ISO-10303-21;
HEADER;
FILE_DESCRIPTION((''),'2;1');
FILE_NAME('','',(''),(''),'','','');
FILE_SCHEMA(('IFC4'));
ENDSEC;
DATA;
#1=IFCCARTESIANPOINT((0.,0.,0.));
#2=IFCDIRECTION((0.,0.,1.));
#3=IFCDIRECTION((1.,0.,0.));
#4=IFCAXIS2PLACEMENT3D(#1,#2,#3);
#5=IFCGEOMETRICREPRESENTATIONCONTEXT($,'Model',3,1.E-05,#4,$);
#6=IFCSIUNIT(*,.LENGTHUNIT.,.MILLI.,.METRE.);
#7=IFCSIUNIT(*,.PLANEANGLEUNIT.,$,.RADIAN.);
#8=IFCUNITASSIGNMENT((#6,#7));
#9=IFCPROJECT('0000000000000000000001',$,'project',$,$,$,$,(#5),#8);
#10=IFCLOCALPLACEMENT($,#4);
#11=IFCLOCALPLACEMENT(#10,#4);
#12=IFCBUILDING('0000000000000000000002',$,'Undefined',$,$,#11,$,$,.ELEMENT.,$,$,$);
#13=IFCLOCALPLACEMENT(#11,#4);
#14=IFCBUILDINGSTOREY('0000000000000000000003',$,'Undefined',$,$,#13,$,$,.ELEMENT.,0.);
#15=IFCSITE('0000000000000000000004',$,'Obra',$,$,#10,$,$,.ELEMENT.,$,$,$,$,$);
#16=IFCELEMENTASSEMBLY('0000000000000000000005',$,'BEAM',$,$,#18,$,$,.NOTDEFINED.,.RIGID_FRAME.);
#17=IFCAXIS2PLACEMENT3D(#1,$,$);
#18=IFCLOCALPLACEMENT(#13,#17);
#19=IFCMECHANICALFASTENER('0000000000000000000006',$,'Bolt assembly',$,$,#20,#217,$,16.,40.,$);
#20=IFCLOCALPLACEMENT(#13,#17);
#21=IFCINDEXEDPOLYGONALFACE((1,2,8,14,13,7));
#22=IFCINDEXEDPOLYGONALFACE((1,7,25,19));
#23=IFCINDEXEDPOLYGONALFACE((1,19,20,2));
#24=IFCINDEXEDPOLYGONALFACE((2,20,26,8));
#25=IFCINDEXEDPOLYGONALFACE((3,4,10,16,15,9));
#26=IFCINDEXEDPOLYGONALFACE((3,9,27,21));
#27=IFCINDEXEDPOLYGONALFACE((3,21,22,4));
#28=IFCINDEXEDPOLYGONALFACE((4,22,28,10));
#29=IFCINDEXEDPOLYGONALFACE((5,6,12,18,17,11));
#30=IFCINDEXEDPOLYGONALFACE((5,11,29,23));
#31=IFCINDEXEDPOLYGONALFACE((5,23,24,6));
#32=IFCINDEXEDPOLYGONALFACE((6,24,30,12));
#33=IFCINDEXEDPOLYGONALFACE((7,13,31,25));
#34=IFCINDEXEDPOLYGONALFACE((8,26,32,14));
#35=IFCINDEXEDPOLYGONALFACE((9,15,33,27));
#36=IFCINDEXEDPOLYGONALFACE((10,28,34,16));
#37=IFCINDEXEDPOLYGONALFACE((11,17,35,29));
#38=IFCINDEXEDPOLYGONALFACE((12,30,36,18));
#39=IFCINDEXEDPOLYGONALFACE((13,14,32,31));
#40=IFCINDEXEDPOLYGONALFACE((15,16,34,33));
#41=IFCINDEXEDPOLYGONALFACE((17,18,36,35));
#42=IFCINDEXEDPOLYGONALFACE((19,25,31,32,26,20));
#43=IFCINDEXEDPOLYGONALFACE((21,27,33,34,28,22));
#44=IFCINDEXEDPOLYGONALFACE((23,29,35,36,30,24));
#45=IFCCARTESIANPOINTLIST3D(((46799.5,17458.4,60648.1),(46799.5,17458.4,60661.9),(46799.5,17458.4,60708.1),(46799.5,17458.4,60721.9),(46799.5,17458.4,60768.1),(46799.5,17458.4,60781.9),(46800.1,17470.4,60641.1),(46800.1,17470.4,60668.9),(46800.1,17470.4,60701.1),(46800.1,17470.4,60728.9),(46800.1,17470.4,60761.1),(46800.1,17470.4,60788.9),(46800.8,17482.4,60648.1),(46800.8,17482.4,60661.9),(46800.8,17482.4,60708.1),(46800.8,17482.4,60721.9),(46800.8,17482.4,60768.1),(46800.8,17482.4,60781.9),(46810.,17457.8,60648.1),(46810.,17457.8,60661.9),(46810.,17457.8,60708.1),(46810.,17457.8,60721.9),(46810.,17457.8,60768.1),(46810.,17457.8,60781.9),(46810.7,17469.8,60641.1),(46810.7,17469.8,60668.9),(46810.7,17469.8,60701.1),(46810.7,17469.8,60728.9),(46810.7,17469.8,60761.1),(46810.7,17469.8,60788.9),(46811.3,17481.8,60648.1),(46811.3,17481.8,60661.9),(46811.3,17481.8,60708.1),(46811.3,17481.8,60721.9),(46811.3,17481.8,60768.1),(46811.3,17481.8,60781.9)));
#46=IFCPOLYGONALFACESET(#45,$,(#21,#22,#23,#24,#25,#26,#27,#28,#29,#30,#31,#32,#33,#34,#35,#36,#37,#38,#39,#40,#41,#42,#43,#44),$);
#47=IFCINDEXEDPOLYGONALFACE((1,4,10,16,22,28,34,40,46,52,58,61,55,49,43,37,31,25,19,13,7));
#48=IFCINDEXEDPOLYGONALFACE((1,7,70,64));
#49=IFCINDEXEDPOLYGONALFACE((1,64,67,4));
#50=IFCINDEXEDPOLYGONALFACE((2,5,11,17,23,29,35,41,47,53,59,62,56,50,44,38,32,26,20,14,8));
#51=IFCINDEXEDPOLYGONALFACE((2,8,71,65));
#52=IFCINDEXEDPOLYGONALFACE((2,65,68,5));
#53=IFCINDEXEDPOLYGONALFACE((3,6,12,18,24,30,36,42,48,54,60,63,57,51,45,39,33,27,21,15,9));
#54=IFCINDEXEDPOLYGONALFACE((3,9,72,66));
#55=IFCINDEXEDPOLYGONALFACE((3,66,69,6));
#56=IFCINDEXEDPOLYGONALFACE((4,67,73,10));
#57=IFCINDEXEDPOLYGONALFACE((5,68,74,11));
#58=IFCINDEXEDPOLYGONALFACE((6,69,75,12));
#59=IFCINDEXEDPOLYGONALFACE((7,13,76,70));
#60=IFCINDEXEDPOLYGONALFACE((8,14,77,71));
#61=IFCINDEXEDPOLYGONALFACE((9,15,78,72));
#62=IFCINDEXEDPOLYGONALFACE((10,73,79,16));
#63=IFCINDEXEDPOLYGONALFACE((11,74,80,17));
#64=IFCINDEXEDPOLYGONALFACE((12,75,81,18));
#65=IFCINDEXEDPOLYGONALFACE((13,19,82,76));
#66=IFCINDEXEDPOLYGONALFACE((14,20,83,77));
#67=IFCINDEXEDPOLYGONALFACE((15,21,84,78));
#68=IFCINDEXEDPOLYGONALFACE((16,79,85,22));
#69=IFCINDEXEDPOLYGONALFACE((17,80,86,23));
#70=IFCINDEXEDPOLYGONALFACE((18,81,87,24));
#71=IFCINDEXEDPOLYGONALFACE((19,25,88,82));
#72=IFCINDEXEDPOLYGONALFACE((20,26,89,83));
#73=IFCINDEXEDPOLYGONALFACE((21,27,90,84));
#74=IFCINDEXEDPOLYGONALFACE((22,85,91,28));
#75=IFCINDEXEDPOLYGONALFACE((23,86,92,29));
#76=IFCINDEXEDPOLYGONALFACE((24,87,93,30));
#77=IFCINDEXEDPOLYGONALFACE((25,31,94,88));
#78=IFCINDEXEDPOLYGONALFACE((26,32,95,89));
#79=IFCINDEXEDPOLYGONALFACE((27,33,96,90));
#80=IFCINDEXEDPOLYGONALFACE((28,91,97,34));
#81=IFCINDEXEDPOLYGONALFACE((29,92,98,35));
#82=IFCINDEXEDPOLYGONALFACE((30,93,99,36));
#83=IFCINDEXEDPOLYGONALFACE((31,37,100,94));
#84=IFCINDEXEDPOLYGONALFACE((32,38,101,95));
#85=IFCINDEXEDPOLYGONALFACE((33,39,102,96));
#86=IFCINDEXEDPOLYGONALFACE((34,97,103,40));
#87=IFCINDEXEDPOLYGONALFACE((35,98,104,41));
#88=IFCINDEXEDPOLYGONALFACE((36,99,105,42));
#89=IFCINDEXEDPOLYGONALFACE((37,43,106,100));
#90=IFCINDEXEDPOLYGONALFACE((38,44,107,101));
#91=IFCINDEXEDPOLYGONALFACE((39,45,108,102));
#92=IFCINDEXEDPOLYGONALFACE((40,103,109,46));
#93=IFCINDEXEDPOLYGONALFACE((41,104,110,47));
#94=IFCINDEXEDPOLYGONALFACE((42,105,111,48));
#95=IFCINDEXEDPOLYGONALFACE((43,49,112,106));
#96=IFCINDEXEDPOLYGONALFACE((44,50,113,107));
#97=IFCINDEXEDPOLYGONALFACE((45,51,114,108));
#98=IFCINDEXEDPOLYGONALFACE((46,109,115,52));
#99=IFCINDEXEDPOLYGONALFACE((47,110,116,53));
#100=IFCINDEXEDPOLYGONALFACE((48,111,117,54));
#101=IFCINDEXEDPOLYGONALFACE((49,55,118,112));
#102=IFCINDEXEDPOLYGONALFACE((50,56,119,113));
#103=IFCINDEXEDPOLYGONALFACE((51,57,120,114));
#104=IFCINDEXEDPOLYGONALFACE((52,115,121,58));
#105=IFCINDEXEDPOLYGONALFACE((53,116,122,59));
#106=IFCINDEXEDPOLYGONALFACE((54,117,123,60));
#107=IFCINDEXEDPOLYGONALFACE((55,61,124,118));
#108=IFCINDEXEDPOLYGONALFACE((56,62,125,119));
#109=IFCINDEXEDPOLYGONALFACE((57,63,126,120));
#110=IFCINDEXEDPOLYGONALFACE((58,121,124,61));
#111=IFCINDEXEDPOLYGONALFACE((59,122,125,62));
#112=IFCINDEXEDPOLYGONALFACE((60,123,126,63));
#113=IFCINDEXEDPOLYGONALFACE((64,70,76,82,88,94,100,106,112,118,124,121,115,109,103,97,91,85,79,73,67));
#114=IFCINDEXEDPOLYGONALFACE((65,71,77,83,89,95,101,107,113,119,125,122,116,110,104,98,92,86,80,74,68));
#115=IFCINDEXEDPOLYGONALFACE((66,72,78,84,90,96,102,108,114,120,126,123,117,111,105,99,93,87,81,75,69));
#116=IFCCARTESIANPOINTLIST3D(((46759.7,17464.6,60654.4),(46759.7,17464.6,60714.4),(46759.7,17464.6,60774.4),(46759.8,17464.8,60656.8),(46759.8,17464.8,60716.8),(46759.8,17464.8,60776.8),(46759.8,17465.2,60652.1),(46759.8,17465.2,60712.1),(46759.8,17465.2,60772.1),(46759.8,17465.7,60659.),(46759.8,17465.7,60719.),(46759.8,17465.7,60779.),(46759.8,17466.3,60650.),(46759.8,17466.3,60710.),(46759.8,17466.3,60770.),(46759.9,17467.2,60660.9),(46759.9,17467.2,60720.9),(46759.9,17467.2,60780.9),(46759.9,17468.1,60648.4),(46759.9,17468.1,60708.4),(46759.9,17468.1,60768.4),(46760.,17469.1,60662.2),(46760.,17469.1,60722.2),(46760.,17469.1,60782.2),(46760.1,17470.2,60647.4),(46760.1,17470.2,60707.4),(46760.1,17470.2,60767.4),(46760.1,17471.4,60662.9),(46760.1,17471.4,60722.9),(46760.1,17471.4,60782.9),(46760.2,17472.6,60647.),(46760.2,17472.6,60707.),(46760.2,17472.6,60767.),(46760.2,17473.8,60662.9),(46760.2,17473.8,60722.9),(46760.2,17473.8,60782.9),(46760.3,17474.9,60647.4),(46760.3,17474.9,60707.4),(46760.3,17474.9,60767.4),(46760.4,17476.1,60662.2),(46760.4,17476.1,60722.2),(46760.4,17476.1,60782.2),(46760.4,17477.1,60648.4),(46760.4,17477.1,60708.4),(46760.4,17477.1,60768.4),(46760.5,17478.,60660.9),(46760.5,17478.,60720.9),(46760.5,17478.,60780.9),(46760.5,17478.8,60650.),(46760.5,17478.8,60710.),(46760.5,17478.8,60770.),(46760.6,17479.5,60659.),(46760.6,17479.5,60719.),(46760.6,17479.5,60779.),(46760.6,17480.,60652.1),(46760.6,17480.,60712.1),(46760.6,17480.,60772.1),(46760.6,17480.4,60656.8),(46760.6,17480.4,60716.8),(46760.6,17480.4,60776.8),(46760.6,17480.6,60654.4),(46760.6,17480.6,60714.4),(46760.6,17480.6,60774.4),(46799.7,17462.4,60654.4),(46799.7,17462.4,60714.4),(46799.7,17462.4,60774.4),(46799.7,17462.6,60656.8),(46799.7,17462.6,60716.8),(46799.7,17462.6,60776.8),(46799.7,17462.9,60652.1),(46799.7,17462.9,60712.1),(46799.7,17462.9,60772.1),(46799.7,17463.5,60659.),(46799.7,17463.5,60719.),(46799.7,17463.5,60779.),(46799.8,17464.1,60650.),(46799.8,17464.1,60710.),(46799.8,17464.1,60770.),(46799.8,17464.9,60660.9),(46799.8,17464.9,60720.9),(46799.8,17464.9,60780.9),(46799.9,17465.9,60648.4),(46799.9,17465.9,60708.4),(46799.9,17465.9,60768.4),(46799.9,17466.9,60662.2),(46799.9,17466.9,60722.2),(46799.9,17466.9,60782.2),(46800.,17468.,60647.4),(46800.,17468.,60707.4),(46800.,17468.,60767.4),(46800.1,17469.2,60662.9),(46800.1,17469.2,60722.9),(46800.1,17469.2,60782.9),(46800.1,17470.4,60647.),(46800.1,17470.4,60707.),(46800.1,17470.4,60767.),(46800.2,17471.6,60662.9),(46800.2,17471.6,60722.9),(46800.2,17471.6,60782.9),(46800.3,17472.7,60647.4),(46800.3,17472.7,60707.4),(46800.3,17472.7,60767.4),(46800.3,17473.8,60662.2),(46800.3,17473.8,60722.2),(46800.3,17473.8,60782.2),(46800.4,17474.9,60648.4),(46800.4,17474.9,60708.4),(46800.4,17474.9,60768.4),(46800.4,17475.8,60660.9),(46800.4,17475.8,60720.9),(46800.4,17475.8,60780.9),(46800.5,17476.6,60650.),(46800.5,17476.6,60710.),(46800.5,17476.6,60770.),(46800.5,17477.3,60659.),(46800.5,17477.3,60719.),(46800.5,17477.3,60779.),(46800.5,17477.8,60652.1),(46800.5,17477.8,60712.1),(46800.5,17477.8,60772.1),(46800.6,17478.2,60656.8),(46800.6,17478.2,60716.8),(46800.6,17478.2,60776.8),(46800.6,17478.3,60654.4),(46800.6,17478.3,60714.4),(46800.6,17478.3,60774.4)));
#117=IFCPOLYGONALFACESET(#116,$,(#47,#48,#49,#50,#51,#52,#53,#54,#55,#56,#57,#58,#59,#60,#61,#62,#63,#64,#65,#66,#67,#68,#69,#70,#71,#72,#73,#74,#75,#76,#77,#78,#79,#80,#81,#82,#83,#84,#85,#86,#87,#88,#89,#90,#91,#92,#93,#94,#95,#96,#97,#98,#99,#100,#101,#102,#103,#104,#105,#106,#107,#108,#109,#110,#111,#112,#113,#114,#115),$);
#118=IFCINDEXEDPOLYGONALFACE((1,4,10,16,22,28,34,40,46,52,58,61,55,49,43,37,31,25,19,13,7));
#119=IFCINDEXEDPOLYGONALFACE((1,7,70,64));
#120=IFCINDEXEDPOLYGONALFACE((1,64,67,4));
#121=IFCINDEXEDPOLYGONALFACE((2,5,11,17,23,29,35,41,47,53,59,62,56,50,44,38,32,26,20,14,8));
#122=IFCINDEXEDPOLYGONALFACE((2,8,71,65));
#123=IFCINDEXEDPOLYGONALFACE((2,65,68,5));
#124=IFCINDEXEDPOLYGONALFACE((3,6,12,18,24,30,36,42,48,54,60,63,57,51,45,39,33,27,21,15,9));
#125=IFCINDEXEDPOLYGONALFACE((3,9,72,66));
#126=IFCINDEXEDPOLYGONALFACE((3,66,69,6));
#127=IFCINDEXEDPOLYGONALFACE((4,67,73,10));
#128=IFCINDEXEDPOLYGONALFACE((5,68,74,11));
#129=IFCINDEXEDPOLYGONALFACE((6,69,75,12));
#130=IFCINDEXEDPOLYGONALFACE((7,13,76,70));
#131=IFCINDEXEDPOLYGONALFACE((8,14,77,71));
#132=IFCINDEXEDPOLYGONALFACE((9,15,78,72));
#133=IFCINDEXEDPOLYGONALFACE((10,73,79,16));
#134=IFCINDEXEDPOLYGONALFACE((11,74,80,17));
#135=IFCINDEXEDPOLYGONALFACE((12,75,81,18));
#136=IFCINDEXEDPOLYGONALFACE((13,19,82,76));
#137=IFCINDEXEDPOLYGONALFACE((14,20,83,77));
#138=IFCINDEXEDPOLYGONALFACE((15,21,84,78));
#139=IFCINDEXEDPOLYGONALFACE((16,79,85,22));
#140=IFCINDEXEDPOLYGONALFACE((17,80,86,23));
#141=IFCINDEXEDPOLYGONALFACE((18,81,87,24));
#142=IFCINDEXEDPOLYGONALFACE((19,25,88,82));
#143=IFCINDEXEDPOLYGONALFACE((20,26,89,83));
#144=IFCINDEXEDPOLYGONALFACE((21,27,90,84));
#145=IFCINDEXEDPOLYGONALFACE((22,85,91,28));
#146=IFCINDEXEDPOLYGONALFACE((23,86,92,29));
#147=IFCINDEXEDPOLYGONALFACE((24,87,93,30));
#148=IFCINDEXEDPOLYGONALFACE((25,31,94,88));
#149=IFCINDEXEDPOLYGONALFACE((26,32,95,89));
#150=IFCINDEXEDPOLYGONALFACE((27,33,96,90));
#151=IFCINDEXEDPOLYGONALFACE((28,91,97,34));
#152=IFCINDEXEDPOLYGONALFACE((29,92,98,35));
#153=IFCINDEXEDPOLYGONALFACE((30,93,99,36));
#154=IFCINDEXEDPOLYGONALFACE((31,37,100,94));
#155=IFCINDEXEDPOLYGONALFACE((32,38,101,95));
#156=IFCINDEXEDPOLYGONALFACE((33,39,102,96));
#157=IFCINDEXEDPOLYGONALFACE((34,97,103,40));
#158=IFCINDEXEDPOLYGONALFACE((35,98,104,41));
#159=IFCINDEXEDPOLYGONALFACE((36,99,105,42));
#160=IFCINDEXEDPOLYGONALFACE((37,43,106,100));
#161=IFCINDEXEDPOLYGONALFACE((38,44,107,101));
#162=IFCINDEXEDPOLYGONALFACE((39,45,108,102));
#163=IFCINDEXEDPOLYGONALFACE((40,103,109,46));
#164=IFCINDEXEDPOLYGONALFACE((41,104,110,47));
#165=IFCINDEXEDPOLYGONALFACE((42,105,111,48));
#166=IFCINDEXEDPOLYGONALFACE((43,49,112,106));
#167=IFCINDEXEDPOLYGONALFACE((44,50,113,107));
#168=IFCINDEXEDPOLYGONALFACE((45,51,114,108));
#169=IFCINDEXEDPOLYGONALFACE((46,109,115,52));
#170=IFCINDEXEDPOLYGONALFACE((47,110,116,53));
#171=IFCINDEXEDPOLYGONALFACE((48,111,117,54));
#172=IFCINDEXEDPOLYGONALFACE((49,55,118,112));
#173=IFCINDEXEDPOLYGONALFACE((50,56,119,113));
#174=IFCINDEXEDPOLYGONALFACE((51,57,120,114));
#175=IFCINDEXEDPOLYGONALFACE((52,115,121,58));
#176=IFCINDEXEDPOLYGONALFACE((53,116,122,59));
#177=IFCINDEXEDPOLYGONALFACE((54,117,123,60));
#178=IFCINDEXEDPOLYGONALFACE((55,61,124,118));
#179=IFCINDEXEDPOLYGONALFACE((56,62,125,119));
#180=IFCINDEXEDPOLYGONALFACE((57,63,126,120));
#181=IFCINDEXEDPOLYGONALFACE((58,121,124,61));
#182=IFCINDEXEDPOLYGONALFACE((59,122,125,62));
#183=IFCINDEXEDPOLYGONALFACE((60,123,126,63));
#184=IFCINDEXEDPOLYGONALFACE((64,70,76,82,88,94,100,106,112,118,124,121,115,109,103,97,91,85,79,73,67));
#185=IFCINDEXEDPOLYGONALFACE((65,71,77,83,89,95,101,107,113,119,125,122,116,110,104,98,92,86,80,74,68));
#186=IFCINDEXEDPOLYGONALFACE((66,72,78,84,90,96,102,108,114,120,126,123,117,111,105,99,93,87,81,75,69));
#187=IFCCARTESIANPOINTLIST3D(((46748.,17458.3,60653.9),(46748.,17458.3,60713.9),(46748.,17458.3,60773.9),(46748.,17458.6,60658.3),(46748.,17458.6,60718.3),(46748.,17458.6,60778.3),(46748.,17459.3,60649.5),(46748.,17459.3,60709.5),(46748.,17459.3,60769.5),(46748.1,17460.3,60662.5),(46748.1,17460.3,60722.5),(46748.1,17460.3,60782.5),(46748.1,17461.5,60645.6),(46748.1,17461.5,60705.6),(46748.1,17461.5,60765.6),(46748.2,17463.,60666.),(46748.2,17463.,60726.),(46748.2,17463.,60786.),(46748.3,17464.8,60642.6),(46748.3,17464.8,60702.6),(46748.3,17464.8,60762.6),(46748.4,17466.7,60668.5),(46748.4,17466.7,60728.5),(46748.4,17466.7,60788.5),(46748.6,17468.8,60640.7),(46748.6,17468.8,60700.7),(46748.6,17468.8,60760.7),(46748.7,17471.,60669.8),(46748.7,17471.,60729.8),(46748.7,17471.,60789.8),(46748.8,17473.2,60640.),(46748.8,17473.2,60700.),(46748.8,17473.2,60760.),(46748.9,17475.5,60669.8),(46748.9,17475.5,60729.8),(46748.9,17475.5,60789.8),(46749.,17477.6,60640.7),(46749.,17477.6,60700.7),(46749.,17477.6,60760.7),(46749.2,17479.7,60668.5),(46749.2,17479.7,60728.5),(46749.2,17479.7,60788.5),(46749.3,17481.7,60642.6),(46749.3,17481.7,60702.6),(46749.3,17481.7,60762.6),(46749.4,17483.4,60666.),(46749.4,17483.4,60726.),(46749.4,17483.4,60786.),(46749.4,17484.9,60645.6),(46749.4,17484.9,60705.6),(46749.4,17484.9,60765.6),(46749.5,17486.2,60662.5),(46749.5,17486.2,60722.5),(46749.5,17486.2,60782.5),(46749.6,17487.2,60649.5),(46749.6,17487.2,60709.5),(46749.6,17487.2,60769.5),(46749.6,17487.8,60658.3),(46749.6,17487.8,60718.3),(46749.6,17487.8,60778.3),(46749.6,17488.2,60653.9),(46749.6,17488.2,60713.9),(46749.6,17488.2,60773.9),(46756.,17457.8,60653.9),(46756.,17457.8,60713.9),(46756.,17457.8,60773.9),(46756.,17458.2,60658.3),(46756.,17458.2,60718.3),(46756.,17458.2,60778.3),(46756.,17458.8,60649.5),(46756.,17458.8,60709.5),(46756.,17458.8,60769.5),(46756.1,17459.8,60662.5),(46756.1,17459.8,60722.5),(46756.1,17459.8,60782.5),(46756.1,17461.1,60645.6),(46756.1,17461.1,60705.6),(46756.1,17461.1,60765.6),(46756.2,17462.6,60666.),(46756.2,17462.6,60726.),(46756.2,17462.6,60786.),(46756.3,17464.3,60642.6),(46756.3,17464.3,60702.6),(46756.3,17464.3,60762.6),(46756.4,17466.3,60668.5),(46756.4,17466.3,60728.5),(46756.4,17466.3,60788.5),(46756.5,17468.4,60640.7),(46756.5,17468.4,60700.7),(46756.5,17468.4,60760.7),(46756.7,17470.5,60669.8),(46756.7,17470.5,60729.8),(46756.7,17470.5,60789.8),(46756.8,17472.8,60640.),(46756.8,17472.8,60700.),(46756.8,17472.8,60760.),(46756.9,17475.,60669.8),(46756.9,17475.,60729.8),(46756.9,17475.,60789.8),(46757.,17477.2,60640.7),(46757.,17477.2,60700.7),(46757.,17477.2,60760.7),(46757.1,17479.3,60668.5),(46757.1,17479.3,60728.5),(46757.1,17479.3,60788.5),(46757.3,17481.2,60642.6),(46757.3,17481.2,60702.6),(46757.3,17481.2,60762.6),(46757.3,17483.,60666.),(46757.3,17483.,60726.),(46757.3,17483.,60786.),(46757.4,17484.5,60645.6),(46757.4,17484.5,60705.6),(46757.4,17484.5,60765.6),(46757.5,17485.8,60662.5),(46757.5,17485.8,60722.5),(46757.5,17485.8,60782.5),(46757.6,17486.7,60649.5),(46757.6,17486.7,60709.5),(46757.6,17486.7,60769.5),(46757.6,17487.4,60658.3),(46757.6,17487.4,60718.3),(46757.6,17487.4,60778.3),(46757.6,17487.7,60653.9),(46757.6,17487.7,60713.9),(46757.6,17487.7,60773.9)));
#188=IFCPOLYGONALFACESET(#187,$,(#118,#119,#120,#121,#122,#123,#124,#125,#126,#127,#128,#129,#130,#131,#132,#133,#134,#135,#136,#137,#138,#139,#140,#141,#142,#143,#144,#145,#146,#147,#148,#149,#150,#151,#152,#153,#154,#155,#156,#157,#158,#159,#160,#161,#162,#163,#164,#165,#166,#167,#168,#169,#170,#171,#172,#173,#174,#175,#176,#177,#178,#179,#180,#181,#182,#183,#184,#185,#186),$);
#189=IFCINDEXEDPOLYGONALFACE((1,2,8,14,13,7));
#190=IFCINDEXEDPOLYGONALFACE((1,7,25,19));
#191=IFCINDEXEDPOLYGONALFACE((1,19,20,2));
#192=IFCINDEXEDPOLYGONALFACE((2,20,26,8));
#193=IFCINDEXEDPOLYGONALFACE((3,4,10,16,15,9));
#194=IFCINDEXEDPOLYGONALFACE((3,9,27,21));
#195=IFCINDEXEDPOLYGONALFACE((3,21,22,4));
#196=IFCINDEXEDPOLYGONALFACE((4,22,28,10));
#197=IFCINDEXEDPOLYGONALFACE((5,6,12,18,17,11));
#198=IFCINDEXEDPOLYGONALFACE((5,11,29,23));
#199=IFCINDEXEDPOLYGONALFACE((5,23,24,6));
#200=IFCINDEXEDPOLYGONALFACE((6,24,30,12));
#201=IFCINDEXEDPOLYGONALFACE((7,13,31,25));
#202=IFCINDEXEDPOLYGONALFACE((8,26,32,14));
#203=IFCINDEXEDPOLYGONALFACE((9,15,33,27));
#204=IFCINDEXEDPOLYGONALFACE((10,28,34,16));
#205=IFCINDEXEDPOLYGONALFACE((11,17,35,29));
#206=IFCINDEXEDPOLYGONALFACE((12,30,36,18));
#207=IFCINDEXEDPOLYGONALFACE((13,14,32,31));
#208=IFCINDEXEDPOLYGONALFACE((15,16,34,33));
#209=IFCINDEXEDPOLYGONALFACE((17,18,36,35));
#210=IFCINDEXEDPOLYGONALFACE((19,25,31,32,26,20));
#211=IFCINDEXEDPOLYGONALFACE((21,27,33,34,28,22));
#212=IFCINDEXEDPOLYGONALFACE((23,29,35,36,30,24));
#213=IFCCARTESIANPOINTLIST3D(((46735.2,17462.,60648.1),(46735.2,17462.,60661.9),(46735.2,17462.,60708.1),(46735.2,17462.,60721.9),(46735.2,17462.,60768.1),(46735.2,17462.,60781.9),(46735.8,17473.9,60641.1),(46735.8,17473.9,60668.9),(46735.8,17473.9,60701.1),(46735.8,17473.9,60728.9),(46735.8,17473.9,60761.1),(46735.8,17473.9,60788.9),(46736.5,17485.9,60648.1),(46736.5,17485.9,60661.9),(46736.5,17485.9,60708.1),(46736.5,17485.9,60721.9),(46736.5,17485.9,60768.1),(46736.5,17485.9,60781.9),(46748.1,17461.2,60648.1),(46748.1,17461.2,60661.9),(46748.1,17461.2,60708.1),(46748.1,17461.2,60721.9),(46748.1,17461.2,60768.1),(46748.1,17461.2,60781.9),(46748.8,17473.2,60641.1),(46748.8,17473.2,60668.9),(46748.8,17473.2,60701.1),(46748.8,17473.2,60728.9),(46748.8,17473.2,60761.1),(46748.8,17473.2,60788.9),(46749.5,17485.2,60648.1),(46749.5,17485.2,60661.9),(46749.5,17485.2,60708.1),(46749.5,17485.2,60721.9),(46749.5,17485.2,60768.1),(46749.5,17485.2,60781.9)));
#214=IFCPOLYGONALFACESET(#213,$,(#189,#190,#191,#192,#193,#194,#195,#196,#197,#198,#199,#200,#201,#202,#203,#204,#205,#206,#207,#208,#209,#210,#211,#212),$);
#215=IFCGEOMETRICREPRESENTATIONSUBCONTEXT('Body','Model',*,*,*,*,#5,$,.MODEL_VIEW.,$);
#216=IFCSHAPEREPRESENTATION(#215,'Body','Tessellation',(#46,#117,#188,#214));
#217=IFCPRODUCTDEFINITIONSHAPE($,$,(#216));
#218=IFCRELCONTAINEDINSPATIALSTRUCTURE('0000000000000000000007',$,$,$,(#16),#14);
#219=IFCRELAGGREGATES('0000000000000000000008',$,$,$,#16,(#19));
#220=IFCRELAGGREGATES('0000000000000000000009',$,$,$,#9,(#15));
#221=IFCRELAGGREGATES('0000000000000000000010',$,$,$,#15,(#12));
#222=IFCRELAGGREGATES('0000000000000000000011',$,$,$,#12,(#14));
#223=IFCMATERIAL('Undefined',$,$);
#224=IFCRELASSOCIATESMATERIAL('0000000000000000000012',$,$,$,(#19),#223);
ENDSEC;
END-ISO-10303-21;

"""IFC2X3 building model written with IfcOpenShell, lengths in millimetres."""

from ifc_helpers import new_model, si_unit, frame, origin_with_axes, origin_2d_with_axis, place, context, subcontext, project, spatial, polyline, circle, outline, extrude, source, transform, mapped, material, element, aggregate, save


model = new_model("IFC2X3")

# Units and contexts
model_context = context("Model", 3, precision=1e-05, world=origin_with_axes())
body_context = subcontext(model_context, "Body", "Model", "MODEL_VIEW")
ifc_project = project(units=[si_unit("LENGTHUNIT", "METRE", prefix="MILLI"), si_unit("PLANEANGLEUNIT", "RADIAN")], contexts=[model_context])

# Site, building, storey
site_placement = place(None, origin_with_axes())
site = spatial("IfcSite", under=ifc_project, at=site_placement, Name="Obra", CompositionType="ELEMENT")
building_placement = place(site_placement, origin_with_axes())
building = spatial("IfcBuilding", under=site, at=building_placement, Name="Undefined", CompositionType="ELEMENT")
storey_placement = place(building_placement, origin_with_axes())
storey = spatial("IfcBuildingStorey", under=building, at=storey_placement, Name="Undefined", CompositionType="ELEMENT", Elevation=0.0)

# Element assembly, mechanical fastener
ifc_material_1 = material(Name="Undefined")
assembly_1_placement = place(storey_placement, origin_with_axes())
assembly_1 = element("IfcElementAssembly", 1, at=assembly_1_placement, inside=storey, Name="BEAM", AssemblyPlace="NOTDEFINED", PredefinedType="RIGID_FRAME")
shared_shape_1 = source(origin_with_axes(), body_context, "Body", "SweptSolid", [
    extrude(outline(polyline([(13.9, 0.0), (6.9, 12.0), (-6.9, 12.0), (-13.9, 0.0), (-6.9, -12.0), (6.9, -12.0), (13.9, 0.0)])), frame((0.0, -19.7, 0.0), z_axis=(0.0, 1.0, 0.0), x_axis=(1.0, 0.0, 0.0)), (0.0, 0.0, 1.0), 10.6),
    extrude(circle(Radius=8.0, at=origin_2d_with_axis()), frame((0.0, -9.1, 0.0), z_axis=(0.0, 1.0, 0.0), x_axis=(1.0, 0.0, 0.0)), (0.0, 0.0, 1.0), 40.0),
    extrude(circle(Radius=15.0, at=origin_2d_with_axis()), frame((0.0, 34.3, 0.0), z_axis=(0.0, 1.0, 0.0), x_axis=(1.0, 0.0, 0.0)), (0.0, 0.0, 1.0), 8.0),
    extrude(outline(polyline([(13.9, 0.0), (6.9, 12.0), (-6.9, 12.0), (-13.9, 0.0), (-6.9, -12.0), (6.9, -12.0), (13.9, 0.0)])), frame((0.0, 42.3, 0.0), z_axis=(0.0, 1.0, 0.0), x_axis=(1.0, 0.0, 0.0)), (0.0, 0.0, 1.0), 13.0),
])
mechanical_fastener_1_placement = place(assembly_1_placement, frame((46788.3, 17421.0, 60835.0), z_axis=(0.055268, 0.998472, 0.0), x_axis=(0.0, 0.0, -1.0)))
mechanical_fastener_1 = element("IfcMechanicalFastener", 2, at=mechanical_fastener_1_placement, material=ifc_material_1, Name="Bolt assembly", NominalDiameter=16.0, NominalLength=40.0, context=body_context, shape_type="MappedRepresentation", body=[
    mapped(shared_shape_1, transform((60.0, 0.0, 50.0))),
    mapped(shared_shape_1, transform((120.0, 0.0, 50.0))),
    mapped(shared_shape_1, transform((180.0, 0.0, 50.0))),
])

aggregate(assembly_1, [mechanical_fastener_1])

save(model, "model.ifc")
